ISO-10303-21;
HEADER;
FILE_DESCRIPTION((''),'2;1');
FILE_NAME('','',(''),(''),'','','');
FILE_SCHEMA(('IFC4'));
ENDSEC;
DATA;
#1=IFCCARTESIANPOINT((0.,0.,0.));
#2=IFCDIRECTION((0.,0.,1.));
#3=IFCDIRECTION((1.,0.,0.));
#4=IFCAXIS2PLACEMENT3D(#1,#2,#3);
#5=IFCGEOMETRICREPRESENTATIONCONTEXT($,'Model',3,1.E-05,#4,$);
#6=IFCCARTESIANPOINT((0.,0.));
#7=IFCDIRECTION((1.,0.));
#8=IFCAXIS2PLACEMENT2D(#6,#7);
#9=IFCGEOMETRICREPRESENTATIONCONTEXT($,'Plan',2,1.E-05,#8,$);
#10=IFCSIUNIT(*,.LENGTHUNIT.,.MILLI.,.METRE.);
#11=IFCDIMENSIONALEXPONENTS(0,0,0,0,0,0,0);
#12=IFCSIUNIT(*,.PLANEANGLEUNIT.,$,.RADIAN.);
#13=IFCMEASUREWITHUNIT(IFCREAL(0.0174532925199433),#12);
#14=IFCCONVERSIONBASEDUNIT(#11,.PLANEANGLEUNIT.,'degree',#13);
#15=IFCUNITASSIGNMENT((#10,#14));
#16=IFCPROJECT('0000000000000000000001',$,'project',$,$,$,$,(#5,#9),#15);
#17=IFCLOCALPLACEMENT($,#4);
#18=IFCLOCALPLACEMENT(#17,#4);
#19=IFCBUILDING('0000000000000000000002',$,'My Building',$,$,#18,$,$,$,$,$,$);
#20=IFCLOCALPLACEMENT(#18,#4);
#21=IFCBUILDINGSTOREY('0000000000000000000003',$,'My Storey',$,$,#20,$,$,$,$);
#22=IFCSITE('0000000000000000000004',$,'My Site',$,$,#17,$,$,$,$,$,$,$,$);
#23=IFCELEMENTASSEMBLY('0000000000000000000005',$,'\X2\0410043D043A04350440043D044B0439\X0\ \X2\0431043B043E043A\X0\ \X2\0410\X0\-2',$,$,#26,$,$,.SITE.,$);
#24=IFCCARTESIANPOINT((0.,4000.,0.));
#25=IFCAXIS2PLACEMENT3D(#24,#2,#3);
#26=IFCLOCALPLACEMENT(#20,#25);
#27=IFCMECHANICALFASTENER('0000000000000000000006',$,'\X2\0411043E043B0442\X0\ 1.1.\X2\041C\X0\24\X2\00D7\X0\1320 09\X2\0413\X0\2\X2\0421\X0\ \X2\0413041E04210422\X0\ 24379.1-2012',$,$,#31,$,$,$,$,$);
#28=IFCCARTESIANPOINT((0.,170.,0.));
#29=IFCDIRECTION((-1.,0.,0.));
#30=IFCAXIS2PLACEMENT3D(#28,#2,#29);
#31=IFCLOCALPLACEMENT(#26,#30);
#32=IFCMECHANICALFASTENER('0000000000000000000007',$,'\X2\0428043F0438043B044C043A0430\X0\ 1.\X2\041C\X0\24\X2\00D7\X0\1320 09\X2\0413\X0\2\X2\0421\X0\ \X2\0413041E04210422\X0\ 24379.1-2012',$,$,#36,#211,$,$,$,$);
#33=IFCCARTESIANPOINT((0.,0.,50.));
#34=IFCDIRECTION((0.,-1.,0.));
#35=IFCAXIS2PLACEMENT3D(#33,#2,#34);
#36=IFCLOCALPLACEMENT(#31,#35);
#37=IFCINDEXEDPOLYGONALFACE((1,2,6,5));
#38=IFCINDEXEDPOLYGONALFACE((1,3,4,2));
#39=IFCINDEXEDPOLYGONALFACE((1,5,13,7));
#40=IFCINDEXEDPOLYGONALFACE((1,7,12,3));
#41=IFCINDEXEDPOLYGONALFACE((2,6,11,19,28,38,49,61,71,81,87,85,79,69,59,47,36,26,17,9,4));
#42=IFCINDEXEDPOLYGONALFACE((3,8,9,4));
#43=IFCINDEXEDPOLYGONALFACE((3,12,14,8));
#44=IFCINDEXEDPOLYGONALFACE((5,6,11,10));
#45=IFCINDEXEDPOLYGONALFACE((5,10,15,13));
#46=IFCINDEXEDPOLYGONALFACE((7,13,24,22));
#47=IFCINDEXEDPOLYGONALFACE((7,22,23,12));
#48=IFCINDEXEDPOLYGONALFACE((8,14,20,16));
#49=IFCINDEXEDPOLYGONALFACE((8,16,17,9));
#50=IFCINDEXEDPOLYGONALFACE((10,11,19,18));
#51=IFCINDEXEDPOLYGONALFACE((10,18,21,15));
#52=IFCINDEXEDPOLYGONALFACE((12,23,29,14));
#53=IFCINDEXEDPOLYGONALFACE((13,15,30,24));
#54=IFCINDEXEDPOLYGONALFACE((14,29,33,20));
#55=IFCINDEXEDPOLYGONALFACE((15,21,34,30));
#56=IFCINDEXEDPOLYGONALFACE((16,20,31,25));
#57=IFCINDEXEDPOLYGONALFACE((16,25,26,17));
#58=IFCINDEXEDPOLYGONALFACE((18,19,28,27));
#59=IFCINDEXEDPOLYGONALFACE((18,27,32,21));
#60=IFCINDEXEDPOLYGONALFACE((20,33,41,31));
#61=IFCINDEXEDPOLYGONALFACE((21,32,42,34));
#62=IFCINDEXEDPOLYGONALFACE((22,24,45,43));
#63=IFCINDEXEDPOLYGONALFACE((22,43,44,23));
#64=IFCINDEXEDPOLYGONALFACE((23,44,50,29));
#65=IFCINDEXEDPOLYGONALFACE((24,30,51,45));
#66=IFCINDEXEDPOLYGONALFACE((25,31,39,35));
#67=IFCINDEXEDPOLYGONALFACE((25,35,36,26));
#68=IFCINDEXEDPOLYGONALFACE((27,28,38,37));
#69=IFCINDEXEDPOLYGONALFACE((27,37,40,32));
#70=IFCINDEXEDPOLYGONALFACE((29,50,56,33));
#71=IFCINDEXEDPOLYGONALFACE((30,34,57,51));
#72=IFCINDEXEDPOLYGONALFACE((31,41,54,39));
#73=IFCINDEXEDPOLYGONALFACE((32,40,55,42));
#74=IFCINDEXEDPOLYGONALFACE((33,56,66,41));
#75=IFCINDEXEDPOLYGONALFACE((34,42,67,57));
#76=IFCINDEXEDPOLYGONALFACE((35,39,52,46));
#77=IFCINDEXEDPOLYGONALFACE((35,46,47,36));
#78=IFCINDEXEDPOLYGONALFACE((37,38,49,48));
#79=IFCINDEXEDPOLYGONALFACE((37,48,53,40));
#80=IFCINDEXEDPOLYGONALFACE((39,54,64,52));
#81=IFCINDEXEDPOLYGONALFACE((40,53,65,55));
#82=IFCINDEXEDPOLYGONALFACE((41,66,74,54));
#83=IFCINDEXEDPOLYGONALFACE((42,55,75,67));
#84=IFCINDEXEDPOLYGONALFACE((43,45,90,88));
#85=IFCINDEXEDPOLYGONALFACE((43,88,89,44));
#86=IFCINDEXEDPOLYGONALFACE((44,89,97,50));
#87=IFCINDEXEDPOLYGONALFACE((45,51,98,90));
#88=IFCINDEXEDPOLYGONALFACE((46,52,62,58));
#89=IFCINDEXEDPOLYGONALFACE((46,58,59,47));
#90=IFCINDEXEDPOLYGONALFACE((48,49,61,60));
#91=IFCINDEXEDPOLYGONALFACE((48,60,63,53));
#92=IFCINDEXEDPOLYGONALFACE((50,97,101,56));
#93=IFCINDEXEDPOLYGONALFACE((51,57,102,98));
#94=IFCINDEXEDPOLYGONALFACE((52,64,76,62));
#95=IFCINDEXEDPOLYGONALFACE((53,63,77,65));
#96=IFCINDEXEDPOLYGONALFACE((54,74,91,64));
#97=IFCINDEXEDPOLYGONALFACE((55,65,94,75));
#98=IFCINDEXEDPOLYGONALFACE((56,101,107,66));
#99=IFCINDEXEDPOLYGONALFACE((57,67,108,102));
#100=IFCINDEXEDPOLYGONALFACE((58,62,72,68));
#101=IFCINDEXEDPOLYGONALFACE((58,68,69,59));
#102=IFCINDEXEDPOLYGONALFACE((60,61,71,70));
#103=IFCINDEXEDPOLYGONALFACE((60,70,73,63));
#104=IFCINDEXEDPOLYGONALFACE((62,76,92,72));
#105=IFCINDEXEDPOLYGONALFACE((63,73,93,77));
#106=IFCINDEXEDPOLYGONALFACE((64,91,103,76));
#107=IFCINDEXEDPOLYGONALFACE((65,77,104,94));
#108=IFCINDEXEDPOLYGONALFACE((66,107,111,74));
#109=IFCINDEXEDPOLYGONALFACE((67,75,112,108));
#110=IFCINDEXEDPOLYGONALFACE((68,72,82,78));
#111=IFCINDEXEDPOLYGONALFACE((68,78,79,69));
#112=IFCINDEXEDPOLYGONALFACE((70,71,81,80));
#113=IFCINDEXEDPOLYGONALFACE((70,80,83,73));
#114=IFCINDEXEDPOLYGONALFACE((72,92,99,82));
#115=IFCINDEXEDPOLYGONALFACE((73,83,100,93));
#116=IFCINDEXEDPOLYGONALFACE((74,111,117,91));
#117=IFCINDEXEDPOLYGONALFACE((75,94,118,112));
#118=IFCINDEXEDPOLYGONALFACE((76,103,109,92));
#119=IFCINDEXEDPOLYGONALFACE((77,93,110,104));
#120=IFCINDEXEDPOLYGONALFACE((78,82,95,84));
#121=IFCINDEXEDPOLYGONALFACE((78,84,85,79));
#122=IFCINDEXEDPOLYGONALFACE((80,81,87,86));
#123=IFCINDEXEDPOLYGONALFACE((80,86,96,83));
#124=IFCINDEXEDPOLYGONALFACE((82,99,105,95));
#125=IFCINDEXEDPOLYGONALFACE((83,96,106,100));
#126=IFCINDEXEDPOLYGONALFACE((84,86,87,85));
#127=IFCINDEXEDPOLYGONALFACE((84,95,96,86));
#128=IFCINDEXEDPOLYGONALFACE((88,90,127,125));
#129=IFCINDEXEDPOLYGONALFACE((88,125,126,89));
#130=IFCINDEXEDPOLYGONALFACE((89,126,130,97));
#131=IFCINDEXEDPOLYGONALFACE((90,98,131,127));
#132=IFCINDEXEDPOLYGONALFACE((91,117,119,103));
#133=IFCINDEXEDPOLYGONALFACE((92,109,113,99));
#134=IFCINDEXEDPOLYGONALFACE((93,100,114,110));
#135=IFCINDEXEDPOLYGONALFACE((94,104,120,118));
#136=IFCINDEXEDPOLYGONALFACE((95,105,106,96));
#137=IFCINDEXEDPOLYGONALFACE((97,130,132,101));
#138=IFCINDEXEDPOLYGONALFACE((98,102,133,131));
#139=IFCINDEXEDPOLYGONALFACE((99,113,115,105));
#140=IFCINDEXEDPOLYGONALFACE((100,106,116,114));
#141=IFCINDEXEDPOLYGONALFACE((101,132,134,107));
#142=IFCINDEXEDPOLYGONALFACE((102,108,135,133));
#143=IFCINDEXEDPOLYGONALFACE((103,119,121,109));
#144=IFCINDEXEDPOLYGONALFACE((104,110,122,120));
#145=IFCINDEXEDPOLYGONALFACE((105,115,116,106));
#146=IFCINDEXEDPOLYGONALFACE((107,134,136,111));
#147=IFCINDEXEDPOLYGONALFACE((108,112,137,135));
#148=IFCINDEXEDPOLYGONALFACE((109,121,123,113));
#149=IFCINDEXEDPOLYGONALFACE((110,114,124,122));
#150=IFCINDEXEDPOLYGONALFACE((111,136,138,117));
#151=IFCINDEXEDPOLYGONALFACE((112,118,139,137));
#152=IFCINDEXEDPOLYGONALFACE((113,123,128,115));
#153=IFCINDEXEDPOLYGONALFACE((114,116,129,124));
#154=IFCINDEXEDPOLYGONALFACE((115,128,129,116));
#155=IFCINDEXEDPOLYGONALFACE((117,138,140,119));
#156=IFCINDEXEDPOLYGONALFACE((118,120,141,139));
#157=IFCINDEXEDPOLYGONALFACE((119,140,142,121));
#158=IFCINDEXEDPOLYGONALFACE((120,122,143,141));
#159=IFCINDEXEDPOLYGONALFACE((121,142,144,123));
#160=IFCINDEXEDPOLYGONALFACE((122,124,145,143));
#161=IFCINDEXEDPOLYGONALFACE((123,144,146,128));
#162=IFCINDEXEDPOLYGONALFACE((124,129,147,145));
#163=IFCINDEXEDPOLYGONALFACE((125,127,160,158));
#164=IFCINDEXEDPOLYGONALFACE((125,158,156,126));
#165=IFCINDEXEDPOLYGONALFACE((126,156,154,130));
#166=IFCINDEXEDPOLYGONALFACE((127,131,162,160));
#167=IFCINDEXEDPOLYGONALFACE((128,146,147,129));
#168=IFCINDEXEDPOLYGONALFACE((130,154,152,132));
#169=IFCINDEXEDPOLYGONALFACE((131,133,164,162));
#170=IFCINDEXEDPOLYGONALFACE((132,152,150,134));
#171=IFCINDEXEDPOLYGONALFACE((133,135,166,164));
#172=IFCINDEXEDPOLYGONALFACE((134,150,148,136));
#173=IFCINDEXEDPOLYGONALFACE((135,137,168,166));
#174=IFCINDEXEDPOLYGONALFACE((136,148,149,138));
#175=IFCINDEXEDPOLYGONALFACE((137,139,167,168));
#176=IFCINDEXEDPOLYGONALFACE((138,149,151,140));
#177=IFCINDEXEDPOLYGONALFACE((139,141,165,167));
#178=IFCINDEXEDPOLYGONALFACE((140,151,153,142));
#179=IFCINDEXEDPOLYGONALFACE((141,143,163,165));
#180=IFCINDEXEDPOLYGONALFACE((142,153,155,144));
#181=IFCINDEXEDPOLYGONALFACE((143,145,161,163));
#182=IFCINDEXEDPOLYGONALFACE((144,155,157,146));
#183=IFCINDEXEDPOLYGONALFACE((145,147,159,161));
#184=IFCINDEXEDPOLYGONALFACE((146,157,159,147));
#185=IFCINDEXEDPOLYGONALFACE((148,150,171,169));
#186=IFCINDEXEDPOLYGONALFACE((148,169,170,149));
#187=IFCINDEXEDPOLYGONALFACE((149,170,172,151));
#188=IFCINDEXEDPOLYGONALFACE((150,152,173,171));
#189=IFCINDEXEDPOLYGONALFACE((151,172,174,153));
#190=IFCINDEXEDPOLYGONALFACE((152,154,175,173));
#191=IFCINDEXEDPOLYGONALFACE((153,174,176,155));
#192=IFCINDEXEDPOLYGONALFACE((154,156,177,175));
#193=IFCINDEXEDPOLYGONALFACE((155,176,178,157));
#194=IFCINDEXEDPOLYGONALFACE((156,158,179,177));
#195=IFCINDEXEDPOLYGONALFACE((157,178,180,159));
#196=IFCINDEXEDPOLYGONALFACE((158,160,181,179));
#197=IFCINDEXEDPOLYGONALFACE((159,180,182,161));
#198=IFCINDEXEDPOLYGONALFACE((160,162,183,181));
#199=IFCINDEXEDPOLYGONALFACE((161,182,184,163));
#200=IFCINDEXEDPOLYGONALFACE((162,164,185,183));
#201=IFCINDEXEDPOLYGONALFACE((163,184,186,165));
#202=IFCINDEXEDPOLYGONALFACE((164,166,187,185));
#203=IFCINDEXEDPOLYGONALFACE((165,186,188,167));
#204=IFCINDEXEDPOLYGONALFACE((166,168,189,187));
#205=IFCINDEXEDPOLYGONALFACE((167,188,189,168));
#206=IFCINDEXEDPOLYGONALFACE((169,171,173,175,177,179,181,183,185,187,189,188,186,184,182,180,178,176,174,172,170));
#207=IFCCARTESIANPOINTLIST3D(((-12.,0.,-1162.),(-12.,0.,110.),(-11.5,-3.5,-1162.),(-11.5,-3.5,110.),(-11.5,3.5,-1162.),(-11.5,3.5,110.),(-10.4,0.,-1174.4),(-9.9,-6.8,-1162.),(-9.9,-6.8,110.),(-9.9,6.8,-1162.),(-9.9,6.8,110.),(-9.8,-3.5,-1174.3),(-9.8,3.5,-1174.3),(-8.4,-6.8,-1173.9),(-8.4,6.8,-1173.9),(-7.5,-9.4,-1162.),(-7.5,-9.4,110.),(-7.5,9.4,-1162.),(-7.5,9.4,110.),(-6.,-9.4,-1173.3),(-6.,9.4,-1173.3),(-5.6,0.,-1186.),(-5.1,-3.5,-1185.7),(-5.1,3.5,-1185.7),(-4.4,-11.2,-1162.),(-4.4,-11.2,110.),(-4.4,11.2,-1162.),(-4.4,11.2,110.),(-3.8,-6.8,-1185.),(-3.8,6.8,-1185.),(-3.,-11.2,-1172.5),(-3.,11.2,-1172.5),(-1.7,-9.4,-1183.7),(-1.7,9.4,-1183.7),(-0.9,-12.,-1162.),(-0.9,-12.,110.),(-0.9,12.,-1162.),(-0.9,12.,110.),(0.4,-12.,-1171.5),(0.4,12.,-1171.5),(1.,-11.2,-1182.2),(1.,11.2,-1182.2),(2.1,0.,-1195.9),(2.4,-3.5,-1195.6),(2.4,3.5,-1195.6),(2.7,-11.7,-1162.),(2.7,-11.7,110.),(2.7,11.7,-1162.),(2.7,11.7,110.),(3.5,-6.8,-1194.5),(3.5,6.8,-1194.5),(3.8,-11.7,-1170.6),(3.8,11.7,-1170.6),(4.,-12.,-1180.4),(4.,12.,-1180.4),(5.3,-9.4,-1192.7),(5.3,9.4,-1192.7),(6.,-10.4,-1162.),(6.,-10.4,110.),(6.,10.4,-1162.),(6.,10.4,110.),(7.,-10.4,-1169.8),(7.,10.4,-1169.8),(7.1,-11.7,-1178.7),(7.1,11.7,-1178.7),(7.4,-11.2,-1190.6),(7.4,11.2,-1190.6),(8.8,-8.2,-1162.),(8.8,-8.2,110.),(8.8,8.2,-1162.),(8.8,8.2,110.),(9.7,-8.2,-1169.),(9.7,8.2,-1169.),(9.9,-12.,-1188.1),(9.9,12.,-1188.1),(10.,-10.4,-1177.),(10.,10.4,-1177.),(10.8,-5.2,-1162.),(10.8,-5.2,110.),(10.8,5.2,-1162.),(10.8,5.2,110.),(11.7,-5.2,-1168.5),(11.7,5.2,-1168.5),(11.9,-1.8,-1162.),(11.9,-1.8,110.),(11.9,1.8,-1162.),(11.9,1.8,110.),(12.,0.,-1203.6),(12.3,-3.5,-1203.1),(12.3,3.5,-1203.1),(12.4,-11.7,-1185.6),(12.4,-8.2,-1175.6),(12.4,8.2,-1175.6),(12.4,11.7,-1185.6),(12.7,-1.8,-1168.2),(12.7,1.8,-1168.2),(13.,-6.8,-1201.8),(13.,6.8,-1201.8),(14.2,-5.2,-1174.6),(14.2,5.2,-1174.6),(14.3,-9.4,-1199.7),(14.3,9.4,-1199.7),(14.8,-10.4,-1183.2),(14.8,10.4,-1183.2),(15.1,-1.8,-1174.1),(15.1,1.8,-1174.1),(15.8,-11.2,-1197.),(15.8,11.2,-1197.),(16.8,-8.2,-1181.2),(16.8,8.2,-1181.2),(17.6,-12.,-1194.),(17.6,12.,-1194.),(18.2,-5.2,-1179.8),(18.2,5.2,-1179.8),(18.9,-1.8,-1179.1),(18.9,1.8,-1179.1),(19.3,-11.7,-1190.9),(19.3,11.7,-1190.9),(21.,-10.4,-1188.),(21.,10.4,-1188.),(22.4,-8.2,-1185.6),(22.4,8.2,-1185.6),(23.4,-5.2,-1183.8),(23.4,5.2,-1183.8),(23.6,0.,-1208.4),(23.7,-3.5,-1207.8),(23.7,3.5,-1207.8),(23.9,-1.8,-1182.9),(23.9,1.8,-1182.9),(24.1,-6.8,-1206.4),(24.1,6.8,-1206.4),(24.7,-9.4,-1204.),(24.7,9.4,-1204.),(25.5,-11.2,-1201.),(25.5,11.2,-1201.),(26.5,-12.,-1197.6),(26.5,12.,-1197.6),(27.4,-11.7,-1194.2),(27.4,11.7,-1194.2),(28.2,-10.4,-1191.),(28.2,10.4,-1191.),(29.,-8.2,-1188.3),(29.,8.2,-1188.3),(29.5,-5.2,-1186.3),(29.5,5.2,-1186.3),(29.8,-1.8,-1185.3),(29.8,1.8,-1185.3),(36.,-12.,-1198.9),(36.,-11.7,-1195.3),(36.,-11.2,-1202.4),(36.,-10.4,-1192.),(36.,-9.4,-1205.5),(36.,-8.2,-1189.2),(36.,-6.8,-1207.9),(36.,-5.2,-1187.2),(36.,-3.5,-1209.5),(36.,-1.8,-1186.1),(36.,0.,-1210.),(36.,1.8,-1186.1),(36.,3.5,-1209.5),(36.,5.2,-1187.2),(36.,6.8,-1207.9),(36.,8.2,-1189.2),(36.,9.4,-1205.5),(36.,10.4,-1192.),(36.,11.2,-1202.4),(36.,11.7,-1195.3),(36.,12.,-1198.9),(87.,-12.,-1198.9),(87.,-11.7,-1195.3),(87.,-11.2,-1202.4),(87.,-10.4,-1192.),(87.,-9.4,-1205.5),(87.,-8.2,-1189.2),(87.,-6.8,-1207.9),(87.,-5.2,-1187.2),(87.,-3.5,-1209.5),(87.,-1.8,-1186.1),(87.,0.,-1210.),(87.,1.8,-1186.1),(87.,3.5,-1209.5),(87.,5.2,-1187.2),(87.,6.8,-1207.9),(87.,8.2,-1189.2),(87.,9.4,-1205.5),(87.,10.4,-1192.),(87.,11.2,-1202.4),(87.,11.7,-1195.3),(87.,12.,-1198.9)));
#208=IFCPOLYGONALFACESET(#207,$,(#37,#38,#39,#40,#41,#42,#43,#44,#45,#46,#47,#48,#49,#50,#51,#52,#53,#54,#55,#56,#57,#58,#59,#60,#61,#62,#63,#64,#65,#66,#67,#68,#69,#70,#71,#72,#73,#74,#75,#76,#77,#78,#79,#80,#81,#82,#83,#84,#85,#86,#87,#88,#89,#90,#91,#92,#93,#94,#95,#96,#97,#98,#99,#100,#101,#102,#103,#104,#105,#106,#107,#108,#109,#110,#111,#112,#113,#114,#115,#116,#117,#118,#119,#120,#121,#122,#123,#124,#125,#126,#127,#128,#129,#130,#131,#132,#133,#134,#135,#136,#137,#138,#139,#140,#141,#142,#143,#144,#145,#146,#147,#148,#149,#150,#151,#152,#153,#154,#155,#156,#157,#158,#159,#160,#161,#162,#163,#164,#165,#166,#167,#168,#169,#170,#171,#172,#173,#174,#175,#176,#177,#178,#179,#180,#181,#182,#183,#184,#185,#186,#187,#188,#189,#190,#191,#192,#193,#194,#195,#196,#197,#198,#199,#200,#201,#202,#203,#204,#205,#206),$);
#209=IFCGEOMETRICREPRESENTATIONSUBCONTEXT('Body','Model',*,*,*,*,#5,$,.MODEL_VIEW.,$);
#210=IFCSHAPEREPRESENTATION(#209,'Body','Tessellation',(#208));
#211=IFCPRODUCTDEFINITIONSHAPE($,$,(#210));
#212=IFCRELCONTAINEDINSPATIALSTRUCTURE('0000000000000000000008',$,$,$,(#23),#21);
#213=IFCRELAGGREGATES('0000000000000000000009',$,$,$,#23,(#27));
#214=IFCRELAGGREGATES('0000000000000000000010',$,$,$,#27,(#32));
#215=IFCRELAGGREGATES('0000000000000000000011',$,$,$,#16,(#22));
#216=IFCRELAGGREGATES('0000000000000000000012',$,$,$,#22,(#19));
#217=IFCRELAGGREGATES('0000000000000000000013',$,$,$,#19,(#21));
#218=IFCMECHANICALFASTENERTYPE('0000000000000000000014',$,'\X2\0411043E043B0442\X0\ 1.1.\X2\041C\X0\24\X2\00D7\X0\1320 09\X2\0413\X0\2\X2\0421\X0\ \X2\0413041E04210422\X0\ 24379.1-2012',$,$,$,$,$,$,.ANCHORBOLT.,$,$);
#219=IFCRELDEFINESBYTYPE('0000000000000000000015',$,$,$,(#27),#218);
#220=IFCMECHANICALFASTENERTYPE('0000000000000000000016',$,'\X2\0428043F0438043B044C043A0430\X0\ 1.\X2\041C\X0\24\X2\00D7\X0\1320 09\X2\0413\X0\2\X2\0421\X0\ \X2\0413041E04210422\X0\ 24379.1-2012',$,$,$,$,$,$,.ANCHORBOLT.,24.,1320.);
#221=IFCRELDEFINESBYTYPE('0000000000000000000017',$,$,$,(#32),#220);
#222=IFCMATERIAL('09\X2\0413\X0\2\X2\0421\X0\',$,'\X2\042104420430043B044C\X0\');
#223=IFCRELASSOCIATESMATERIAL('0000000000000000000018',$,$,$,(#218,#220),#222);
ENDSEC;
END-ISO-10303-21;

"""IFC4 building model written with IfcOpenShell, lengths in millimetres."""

from ifc_helpers import new_model, entity, si_unit, converted_unit, frame, origin_with_axes, origin_2d_with_axis, place, context, subcontext, project, spatial, source, transform, mapped, material, type_object, type_shapes, element, aggregate, save


model = new_model("IFC4")

# Units and contexts
model_context = context("Model", 3, precision=1e-05, world=origin_with_axes())
plan_context = context("Plan", 2, precision=1e-05, world=origin_2d_with_axis())
body_context = subcontext(model_context, "Body", "Model", "MODEL_VIEW")
ifc_project = project(units=[si_unit("LENGTHUNIT", "METRE", prefix="MILLI"), converted_unit("PLANEANGLEUNIT", "degree", entity("IfcReal", 0.0174532925199433), si_unit("PLANEANGLEUNIT", "RADIAN"), dimensions=[0, 0, 0, 0, 0, 0, 0])], contexts=[model_context, plan_context])

# Site, building, storey
site_placement = place(None, origin_with_axes())
site = spatial("IfcSite", under=ifc_project, at=site_placement, Name="My Site")
building_placement = place(site_placement, origin_with_axes())
building = spatial("IfcBuilding", under=site, at=building_placement, Name="My Building")
storey_placement = place(building_placement, origin_with_axes())
storey = spatial("IfcBuildingStorey", under=building, at=storey_placement, Name="My Storey")

# Shared definitions
placement = place(storey_placement, frame((0.0, 4000.0, 0.0), z_axis=(0.0, 0.0, 1.0), x_axis=(1.0, 0.0, 0.0)))

# Element assembly, mechanical fasteners
assembly_1 = element("IfcElementAssembly", 1, at=placement, inside=storey, Name="Анкерный блок А-2", AssemblyPlace="SITE")
ifc_material_1 = material(Name="09Г2С", Category="Сталь")
mechanical_fastener_type_1 = type_object("IfcMechanicalFastenerType", Name="Болт 1.1.М24×1320 09Г2С ГОСТ 24379.1-2012", PredefinedType="ANCHORBOLT", material=ifc_material_1)
mechanical_fastener_type_2 = type_object("IfcMechanicalFastenerType", Name="Шпилька 1.М24×1320 09Г2С ГОСТ 24379.1-2012", NominalDiameter=24.0, NominalLength=1320.0, PredefinedType="ANCHORBOLT", material=ifc_material_1)
shared_shape_1 = source(frame((0.0, 0.0, 110.0), z_axis=(0.0, 0.0, 1.0), x_axis=(1.0, 0.0, 0.0)), body_context, "Body", "AdvancedSweptSolid", [
    entity("IfcSweptDiskSolid", entity("IfcIndexedPolyCurve", entity("IfcCartesianPointList3D", [[0.0, 0.0, 0.0], [0.0, 0.0, -1272.0], [10.5, 0.0, -1297.5], [36.0, 0.0, -1308.0], [87.0, 0.0, -1308.0]]), [entity("IfcLineIndex", [1, 2]), entity("IfcArcIndex", [2, 3, 4]), entity("IfcLineIndex", [4, 5])]), 12.0),
])
type_shapes(mechanical_fastener_type_2, [shared_shape_1])
mechanical_fastener_1_placement = place(placement, frame((0.0, 170.0, 0.0), z_axis=(0.0, 0.0, 1.0), x_axis=(-1.0, 0.0, 0.0)))
mechanical_fastener_1 = element("IfcMechanicalFastener", 2, at=mechanical_fastener_1_placement, type_object=mechanical_fastener_type_1, Name="Болт 1.1.М24×1320 09Г2С ГОСТ 24379.1-2012")
aggregate(assembly_1, [mechanical_fastener_1])
mechanical_fastener_2_placement = place(mechanical_fastener_1_placement, frame((0.0, 0.0, 50.0), z_axis=(0.0, 0.0, 1.0), x_axis=(0.0, -1.0, 0.0)))
mechanical_fastener_2 = element("IfcMechanicalFastener", 3, at=mechanical_fastener_2_placement, type_object=mechanical_fastener_type_2, Name="Шпилька 1.М24×1320 09Г2С ГОСТ 24379.1-2012", context=body_context, shape_type="MappedRepresentation", body=[
    mapped(shared_shape_1, transform((0.0, 0.0, 0.0), x_axis=(1.0, 0.0, 0.0), y_axis=(0.0, 1.0, 0.0), z_axis=(0.0, 0.0, 1.0), scale=1.0)),
])

aggregate(mechanical_fastener_1, [mechanical_fastener_2])

save(model, "model.ifc")
